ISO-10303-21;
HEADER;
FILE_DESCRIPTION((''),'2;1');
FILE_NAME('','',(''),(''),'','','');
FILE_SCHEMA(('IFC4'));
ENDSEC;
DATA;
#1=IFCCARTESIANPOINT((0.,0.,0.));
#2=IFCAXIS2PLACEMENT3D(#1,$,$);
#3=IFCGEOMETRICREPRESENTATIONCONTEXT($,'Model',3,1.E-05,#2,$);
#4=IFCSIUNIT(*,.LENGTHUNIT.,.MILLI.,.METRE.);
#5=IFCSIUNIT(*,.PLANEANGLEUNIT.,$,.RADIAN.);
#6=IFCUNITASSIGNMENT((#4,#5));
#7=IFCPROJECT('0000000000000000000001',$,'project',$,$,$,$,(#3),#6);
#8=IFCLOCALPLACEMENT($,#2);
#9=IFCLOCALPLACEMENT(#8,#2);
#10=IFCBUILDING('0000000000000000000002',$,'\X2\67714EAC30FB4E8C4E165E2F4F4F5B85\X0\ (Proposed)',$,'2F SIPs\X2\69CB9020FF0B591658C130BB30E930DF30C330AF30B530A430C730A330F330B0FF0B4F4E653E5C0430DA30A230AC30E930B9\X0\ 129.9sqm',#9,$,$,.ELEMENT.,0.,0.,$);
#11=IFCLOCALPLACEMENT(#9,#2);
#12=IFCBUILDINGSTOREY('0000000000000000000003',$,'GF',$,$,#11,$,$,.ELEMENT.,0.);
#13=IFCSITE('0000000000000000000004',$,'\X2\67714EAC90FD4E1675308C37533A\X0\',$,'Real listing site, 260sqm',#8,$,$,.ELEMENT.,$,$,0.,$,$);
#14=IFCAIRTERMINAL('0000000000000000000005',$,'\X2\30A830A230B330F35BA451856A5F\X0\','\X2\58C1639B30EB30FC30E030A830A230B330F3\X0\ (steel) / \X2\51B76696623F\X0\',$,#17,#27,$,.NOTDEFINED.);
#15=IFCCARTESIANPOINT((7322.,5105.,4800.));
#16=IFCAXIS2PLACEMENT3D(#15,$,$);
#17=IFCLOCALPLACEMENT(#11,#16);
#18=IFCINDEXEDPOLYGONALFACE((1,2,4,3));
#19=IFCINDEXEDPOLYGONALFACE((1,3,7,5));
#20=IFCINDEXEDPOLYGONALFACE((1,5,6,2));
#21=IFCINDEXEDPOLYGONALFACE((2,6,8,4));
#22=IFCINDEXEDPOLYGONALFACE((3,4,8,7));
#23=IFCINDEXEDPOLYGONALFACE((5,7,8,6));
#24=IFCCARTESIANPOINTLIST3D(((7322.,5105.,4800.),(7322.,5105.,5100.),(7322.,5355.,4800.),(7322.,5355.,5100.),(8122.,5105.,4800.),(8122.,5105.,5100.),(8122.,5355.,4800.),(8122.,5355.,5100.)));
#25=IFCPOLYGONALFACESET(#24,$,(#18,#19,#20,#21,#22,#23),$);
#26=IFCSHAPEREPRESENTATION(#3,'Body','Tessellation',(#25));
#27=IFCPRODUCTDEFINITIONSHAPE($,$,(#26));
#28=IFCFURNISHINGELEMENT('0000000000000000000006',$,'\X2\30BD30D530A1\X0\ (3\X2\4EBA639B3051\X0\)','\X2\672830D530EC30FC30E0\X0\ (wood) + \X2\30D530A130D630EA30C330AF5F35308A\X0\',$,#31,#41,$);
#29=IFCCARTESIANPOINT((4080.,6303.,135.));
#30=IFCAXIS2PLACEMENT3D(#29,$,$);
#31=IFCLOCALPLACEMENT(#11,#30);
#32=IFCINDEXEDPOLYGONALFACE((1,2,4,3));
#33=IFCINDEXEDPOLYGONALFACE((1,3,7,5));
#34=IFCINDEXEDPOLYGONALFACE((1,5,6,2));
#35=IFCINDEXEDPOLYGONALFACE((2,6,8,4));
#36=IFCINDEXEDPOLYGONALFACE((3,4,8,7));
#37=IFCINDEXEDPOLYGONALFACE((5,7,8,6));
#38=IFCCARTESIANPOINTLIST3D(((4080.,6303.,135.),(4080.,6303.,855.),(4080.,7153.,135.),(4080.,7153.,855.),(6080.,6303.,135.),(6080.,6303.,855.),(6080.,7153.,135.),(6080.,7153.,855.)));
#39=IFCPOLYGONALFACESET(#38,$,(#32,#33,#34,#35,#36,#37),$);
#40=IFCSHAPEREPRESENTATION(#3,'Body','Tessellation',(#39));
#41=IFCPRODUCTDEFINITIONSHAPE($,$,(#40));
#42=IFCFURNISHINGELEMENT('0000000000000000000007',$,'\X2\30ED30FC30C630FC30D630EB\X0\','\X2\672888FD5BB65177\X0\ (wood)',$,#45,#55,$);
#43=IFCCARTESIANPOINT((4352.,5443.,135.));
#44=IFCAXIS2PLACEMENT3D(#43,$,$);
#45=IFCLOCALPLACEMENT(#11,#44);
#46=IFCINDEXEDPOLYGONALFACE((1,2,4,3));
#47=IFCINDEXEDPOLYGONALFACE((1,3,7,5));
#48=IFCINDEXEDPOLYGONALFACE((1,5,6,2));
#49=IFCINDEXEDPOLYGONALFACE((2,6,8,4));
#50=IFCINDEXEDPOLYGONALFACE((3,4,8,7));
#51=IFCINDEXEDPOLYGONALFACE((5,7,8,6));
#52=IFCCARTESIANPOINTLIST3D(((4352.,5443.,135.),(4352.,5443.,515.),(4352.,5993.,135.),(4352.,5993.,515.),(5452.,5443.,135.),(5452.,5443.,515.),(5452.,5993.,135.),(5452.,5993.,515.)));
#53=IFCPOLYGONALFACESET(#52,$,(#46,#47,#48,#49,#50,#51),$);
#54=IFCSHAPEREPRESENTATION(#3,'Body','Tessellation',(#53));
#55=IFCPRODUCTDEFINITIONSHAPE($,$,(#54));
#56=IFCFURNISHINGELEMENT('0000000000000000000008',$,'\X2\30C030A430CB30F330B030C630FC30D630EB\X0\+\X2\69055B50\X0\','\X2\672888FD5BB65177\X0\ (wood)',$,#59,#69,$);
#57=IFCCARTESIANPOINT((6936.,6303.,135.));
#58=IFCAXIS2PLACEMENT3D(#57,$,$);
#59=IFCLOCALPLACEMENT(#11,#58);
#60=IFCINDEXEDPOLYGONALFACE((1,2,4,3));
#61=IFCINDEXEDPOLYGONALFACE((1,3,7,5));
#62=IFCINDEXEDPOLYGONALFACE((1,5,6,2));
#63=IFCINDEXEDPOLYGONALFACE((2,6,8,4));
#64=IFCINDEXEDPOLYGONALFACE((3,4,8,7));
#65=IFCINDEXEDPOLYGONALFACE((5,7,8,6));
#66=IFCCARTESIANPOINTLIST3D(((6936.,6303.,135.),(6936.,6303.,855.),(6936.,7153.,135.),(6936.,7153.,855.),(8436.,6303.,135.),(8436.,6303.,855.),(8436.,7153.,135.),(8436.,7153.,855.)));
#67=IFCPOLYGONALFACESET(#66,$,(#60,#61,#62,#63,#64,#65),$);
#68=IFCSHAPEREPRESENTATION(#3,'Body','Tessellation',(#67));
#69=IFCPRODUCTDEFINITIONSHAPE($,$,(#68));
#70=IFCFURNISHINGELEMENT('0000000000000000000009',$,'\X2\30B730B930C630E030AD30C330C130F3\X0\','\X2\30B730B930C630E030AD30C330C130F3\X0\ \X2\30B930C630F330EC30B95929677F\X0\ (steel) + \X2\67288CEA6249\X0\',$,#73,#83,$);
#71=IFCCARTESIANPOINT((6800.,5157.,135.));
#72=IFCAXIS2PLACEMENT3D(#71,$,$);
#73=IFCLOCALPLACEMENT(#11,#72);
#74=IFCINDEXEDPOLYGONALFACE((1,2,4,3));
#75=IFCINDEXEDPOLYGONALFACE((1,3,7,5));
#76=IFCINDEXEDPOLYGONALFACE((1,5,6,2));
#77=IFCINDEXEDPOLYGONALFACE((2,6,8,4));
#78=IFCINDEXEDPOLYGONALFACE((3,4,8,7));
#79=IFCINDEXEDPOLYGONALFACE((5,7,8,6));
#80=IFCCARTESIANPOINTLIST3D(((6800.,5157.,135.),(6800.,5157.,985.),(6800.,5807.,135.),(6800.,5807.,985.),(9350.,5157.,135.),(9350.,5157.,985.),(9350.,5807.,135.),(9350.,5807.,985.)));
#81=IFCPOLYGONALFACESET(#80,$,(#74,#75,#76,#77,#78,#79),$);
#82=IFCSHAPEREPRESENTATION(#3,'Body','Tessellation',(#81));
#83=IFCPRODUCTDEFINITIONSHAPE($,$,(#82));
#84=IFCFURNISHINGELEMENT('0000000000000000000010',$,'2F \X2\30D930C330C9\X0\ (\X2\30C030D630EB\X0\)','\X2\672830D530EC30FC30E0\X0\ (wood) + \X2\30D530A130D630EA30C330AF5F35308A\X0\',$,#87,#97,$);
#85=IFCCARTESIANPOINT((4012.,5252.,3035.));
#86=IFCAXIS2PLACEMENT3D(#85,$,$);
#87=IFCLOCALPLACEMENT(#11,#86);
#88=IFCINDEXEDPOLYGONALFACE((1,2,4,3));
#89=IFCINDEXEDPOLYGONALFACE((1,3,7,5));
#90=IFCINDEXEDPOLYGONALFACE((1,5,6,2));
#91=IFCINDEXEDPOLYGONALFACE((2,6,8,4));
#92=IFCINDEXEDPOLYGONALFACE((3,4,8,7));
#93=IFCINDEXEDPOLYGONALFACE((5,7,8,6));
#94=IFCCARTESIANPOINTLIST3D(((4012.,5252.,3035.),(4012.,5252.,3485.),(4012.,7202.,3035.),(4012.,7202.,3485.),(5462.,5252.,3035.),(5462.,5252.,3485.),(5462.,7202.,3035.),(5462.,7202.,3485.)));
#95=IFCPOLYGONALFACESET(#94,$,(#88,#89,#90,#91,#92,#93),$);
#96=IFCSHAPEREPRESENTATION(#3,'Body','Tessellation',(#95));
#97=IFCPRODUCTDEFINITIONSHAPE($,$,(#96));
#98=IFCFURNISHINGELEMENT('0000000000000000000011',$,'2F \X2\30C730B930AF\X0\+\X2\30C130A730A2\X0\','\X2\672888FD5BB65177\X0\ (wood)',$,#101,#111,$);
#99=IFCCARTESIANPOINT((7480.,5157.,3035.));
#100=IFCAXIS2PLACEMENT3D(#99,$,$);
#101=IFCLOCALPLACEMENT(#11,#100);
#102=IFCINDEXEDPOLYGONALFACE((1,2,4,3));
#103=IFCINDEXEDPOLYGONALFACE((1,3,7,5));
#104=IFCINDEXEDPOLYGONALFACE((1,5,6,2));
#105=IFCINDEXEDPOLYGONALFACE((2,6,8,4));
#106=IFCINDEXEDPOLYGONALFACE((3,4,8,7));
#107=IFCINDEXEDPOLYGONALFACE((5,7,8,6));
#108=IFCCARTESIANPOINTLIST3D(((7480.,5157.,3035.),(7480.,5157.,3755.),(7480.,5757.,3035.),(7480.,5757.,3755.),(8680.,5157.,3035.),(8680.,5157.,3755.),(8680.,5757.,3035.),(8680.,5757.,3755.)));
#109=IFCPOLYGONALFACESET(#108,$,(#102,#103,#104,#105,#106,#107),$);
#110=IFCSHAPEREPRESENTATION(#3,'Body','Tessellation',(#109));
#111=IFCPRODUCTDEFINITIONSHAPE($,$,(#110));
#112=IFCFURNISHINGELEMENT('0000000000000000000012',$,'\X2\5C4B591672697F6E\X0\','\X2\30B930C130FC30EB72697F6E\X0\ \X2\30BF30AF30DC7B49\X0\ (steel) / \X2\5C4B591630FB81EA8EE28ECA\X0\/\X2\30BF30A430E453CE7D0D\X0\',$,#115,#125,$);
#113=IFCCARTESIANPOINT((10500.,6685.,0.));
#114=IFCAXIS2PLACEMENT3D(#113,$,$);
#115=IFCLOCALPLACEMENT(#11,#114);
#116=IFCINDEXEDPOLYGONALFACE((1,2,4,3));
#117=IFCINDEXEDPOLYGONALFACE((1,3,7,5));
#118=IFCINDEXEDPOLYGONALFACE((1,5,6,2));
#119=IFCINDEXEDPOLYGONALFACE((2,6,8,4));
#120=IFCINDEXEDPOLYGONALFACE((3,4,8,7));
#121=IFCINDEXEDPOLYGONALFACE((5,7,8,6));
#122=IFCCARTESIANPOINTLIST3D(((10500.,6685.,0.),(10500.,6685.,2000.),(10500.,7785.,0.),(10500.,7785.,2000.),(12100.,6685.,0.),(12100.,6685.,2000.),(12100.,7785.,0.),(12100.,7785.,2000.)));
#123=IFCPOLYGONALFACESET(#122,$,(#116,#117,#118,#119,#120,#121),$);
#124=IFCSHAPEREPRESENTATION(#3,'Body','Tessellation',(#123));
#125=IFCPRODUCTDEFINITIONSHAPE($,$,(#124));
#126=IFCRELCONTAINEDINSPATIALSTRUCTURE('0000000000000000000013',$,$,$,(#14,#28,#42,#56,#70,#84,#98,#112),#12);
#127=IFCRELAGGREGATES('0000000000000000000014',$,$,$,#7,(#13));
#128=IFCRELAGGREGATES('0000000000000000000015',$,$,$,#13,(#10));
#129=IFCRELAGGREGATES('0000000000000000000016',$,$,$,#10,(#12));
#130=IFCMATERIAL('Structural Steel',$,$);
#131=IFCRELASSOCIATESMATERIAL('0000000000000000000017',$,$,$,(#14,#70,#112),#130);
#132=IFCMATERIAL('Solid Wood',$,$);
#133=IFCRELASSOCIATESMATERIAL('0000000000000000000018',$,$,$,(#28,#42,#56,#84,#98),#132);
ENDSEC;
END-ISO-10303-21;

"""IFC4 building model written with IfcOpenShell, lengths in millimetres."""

from ifc_helpers import new_model, si_unit, frame, frame_2d, origin, place, context, project, spatial, rectangle, extrude, material, element, save


model = new_model("IFC4")

# Units and contexts
model_context = context("Model", 3, precision=1e-05, world=origin())
ifc_project = project(units=[si_unit("LENGTHUNIT", "METRE", prefix="MILLI"), si_unit("PLANEANGLEUNIT", "RADIAN")], contexts=[model_context])

# Site, building, storey
site_placement = place(None, origin())
site = spatial("IfcSite", under=ifc_project, at=site_placement, Name="東京都世田谷区", ObjectType="Real listing site, 260sqm", CompositionType="ELEMENT", RefElevation=0.0)
building_placement = place(site_placement, origin())
building = spatial("IfcBuilding", under=site, at=building_placement, Name="東京・二世帯住宅 (Proposed)", ObjectType="2F SIPs構造＋外壁セラミックサイディング＋低放射ペアガラス 129.9sqm", CompositionType="ELEMENT", ElevationOfRefHeight=0.0, ElevationOfTerrain=0.0)
storey_placement = place(building_placement, origin())
storey = spatial("IfcBuildingStorey", under=building, at=storey_placement, Name="GF", CompositionType="ELEMENT", Elevation=0.0)

# Shared definitions
ifc_material_1 = material(Name="Solid Wood")

# Shared definitions
ifc_material_2 = material(Name="Structural Steel")

# Air terminal
air_terminal_1_placement = place(storey_placement, frame((7322.0, 5105.0, 4800.0)))
element("IfcAirTerminal", 1, at=air_terminal_1_placement, inside=storey, material=ifc_material_2, Name="エアコン室内機", Description="壁掛ルームエアコン (steel) / 冷暖房", PredefinedType="NOTDEFINED", context=model_context, shape_type="SweptSolid", body=[
    extrude(rectangle(XDim=800.0, YDim=250.0, at=frame_2d((400.0, 125.0))), frame((7322.0, 5105.0, 4800.0)), (0.0, 0.0, 1.0), 300.0),
])

# Furnishing elements
furnishing_1_placement = place(storey_placement, frame((4080.0, 6303.0, 135.0)))
element("IfcFurnishingElement", 2, at=furnishing_1_placement, inside=storey, material=ifc_material_1, Name="ソファ (3人掛け)", Description="木フレーム (wood) + ファブリック張り", context=model_context, shape_type="SweptSolid", body=[
    extrude(rectangle(XDim=2000.0, YDim=850.0, at=frame_2d((1000.0, 425.0))), frame((4080.0, 6303.0, 135.0)), (0.0, 0.0, 1.0), 720.0),
])
furnishing_2_placement = place(storey_placement, frame((4352.0, 5443.0, 135.0)))
element("IfcFurnishingElement", 3, at=furnishing_2_placement, inside=storey, material=ifc_material_1, Name="ローテーブル", Description="木製家具 (wood)", context=model_context, shape_type="SweptSolid", body=[
    extrude(rectangle(XDim=1100.0, YDim=550.0, at=frame_2d((550.0, 275.0))), frame((4352.0, 5443.0, 135.0)), (0.0, 0.0, 1.0), 380.0),
])
furnishing_3_placement = place(storey_placement, frame((6936.0, 6303.0, 135.0)))
element("IfcFurnishingElement", 4, at=furnishing_3_placement, inside=storey, material=ifc_material_1, Name="ダイニングテーブル+椅子", Description="木製家具 (wood)", context=model_context, shape_type="SweptSolid", body=[
    extrude(rectangle(XDim=1500.0, YDim=850.0, at=frame_2d((750.0, 425.0))), frame((6936.0, 6303.0, 135.0)), (0.0, 0.0, 1.0), 720.0),
])
furnishing_4_placement = place(storey_placement, frame((6800.0, 5157.0, 135.0)))
element("IfcFurnishingElement", 5, at=furnishing_4_placement, inside=storey, material=ifc_material_2, Name="システムキッチン", Description="システムキッチン ステンレス天板 (steel) + 木質扉", context=model_context, shape_type="SweptSolid", body=[
    extrude(rectangle(XDim=2550.0, YDim=650.0, at=frame_2d((1275.0, 325.0))), frame((6800.0, 5157.0, 135.0)), (0.0, 0.0, 1.0), 850.0),
])
furnishing_5_placement = place(storey_placement, frame((4012.0, 5252.0, 3035.0)))
element("IfcFurnishingElement", 6, at=furnishing_5_placement, inside=storey, material=ifc_material_1, Name="2F ベッド (ダブル)", Description="木フレーム (wood) + ファブリック張り", context=model_context, shape_type="SweptSolid", body=[
    extrude(rectangle(XDim=1450.0, YDim=1950.0, at=frame_2d((725.0, 975.0))), frame((4012.0, 5252.0, 3035.0)), (0.0, 0.0, 1.0), 450.0),
])
furnishing_6_placement = place(storey_placement, frame((7480.0, 5157.0, 3035.0)))
element("IfcFurnishingElement", 7, at=furnishing_6_placement, inside=storey, material=ifc_material_1, Name="2F デスク+チェア", Description="木製家具 (wood)", context=model_context, shape_type="SweptSolid", body=[
    extrude(rectangle(XDim=1200.0, YDim=600.0, at=frame_2d((600.0, 300.0))), frame((7480.0, 5157.0, 3035.0)), (0.0, 0.0, 1.0), 720.0),
])
furnishing_7_placement = place(storey_placement, frame((10500.0, 6685.0, 0.0)))
element("IfcFurnishingElement", 8, at=furnishing_7_placement, inside=storey, material=ifc_material_2, Name="屋外物置", Description="スチール物置 タクボ等 (steel) / 屋外・自転車/タイヤ収納", context=model_context, shape_type="SweptSolid", body=[
    extrude(rectangle(XDim=1600.0, YDim=1100.0, at=frame_2d((800.0, 550.0))), frame((10500.0, 6685.0, 0.0)), (0.0, 0.0, 1.0), 2000.0),
])

save(model, "model.ifc")
